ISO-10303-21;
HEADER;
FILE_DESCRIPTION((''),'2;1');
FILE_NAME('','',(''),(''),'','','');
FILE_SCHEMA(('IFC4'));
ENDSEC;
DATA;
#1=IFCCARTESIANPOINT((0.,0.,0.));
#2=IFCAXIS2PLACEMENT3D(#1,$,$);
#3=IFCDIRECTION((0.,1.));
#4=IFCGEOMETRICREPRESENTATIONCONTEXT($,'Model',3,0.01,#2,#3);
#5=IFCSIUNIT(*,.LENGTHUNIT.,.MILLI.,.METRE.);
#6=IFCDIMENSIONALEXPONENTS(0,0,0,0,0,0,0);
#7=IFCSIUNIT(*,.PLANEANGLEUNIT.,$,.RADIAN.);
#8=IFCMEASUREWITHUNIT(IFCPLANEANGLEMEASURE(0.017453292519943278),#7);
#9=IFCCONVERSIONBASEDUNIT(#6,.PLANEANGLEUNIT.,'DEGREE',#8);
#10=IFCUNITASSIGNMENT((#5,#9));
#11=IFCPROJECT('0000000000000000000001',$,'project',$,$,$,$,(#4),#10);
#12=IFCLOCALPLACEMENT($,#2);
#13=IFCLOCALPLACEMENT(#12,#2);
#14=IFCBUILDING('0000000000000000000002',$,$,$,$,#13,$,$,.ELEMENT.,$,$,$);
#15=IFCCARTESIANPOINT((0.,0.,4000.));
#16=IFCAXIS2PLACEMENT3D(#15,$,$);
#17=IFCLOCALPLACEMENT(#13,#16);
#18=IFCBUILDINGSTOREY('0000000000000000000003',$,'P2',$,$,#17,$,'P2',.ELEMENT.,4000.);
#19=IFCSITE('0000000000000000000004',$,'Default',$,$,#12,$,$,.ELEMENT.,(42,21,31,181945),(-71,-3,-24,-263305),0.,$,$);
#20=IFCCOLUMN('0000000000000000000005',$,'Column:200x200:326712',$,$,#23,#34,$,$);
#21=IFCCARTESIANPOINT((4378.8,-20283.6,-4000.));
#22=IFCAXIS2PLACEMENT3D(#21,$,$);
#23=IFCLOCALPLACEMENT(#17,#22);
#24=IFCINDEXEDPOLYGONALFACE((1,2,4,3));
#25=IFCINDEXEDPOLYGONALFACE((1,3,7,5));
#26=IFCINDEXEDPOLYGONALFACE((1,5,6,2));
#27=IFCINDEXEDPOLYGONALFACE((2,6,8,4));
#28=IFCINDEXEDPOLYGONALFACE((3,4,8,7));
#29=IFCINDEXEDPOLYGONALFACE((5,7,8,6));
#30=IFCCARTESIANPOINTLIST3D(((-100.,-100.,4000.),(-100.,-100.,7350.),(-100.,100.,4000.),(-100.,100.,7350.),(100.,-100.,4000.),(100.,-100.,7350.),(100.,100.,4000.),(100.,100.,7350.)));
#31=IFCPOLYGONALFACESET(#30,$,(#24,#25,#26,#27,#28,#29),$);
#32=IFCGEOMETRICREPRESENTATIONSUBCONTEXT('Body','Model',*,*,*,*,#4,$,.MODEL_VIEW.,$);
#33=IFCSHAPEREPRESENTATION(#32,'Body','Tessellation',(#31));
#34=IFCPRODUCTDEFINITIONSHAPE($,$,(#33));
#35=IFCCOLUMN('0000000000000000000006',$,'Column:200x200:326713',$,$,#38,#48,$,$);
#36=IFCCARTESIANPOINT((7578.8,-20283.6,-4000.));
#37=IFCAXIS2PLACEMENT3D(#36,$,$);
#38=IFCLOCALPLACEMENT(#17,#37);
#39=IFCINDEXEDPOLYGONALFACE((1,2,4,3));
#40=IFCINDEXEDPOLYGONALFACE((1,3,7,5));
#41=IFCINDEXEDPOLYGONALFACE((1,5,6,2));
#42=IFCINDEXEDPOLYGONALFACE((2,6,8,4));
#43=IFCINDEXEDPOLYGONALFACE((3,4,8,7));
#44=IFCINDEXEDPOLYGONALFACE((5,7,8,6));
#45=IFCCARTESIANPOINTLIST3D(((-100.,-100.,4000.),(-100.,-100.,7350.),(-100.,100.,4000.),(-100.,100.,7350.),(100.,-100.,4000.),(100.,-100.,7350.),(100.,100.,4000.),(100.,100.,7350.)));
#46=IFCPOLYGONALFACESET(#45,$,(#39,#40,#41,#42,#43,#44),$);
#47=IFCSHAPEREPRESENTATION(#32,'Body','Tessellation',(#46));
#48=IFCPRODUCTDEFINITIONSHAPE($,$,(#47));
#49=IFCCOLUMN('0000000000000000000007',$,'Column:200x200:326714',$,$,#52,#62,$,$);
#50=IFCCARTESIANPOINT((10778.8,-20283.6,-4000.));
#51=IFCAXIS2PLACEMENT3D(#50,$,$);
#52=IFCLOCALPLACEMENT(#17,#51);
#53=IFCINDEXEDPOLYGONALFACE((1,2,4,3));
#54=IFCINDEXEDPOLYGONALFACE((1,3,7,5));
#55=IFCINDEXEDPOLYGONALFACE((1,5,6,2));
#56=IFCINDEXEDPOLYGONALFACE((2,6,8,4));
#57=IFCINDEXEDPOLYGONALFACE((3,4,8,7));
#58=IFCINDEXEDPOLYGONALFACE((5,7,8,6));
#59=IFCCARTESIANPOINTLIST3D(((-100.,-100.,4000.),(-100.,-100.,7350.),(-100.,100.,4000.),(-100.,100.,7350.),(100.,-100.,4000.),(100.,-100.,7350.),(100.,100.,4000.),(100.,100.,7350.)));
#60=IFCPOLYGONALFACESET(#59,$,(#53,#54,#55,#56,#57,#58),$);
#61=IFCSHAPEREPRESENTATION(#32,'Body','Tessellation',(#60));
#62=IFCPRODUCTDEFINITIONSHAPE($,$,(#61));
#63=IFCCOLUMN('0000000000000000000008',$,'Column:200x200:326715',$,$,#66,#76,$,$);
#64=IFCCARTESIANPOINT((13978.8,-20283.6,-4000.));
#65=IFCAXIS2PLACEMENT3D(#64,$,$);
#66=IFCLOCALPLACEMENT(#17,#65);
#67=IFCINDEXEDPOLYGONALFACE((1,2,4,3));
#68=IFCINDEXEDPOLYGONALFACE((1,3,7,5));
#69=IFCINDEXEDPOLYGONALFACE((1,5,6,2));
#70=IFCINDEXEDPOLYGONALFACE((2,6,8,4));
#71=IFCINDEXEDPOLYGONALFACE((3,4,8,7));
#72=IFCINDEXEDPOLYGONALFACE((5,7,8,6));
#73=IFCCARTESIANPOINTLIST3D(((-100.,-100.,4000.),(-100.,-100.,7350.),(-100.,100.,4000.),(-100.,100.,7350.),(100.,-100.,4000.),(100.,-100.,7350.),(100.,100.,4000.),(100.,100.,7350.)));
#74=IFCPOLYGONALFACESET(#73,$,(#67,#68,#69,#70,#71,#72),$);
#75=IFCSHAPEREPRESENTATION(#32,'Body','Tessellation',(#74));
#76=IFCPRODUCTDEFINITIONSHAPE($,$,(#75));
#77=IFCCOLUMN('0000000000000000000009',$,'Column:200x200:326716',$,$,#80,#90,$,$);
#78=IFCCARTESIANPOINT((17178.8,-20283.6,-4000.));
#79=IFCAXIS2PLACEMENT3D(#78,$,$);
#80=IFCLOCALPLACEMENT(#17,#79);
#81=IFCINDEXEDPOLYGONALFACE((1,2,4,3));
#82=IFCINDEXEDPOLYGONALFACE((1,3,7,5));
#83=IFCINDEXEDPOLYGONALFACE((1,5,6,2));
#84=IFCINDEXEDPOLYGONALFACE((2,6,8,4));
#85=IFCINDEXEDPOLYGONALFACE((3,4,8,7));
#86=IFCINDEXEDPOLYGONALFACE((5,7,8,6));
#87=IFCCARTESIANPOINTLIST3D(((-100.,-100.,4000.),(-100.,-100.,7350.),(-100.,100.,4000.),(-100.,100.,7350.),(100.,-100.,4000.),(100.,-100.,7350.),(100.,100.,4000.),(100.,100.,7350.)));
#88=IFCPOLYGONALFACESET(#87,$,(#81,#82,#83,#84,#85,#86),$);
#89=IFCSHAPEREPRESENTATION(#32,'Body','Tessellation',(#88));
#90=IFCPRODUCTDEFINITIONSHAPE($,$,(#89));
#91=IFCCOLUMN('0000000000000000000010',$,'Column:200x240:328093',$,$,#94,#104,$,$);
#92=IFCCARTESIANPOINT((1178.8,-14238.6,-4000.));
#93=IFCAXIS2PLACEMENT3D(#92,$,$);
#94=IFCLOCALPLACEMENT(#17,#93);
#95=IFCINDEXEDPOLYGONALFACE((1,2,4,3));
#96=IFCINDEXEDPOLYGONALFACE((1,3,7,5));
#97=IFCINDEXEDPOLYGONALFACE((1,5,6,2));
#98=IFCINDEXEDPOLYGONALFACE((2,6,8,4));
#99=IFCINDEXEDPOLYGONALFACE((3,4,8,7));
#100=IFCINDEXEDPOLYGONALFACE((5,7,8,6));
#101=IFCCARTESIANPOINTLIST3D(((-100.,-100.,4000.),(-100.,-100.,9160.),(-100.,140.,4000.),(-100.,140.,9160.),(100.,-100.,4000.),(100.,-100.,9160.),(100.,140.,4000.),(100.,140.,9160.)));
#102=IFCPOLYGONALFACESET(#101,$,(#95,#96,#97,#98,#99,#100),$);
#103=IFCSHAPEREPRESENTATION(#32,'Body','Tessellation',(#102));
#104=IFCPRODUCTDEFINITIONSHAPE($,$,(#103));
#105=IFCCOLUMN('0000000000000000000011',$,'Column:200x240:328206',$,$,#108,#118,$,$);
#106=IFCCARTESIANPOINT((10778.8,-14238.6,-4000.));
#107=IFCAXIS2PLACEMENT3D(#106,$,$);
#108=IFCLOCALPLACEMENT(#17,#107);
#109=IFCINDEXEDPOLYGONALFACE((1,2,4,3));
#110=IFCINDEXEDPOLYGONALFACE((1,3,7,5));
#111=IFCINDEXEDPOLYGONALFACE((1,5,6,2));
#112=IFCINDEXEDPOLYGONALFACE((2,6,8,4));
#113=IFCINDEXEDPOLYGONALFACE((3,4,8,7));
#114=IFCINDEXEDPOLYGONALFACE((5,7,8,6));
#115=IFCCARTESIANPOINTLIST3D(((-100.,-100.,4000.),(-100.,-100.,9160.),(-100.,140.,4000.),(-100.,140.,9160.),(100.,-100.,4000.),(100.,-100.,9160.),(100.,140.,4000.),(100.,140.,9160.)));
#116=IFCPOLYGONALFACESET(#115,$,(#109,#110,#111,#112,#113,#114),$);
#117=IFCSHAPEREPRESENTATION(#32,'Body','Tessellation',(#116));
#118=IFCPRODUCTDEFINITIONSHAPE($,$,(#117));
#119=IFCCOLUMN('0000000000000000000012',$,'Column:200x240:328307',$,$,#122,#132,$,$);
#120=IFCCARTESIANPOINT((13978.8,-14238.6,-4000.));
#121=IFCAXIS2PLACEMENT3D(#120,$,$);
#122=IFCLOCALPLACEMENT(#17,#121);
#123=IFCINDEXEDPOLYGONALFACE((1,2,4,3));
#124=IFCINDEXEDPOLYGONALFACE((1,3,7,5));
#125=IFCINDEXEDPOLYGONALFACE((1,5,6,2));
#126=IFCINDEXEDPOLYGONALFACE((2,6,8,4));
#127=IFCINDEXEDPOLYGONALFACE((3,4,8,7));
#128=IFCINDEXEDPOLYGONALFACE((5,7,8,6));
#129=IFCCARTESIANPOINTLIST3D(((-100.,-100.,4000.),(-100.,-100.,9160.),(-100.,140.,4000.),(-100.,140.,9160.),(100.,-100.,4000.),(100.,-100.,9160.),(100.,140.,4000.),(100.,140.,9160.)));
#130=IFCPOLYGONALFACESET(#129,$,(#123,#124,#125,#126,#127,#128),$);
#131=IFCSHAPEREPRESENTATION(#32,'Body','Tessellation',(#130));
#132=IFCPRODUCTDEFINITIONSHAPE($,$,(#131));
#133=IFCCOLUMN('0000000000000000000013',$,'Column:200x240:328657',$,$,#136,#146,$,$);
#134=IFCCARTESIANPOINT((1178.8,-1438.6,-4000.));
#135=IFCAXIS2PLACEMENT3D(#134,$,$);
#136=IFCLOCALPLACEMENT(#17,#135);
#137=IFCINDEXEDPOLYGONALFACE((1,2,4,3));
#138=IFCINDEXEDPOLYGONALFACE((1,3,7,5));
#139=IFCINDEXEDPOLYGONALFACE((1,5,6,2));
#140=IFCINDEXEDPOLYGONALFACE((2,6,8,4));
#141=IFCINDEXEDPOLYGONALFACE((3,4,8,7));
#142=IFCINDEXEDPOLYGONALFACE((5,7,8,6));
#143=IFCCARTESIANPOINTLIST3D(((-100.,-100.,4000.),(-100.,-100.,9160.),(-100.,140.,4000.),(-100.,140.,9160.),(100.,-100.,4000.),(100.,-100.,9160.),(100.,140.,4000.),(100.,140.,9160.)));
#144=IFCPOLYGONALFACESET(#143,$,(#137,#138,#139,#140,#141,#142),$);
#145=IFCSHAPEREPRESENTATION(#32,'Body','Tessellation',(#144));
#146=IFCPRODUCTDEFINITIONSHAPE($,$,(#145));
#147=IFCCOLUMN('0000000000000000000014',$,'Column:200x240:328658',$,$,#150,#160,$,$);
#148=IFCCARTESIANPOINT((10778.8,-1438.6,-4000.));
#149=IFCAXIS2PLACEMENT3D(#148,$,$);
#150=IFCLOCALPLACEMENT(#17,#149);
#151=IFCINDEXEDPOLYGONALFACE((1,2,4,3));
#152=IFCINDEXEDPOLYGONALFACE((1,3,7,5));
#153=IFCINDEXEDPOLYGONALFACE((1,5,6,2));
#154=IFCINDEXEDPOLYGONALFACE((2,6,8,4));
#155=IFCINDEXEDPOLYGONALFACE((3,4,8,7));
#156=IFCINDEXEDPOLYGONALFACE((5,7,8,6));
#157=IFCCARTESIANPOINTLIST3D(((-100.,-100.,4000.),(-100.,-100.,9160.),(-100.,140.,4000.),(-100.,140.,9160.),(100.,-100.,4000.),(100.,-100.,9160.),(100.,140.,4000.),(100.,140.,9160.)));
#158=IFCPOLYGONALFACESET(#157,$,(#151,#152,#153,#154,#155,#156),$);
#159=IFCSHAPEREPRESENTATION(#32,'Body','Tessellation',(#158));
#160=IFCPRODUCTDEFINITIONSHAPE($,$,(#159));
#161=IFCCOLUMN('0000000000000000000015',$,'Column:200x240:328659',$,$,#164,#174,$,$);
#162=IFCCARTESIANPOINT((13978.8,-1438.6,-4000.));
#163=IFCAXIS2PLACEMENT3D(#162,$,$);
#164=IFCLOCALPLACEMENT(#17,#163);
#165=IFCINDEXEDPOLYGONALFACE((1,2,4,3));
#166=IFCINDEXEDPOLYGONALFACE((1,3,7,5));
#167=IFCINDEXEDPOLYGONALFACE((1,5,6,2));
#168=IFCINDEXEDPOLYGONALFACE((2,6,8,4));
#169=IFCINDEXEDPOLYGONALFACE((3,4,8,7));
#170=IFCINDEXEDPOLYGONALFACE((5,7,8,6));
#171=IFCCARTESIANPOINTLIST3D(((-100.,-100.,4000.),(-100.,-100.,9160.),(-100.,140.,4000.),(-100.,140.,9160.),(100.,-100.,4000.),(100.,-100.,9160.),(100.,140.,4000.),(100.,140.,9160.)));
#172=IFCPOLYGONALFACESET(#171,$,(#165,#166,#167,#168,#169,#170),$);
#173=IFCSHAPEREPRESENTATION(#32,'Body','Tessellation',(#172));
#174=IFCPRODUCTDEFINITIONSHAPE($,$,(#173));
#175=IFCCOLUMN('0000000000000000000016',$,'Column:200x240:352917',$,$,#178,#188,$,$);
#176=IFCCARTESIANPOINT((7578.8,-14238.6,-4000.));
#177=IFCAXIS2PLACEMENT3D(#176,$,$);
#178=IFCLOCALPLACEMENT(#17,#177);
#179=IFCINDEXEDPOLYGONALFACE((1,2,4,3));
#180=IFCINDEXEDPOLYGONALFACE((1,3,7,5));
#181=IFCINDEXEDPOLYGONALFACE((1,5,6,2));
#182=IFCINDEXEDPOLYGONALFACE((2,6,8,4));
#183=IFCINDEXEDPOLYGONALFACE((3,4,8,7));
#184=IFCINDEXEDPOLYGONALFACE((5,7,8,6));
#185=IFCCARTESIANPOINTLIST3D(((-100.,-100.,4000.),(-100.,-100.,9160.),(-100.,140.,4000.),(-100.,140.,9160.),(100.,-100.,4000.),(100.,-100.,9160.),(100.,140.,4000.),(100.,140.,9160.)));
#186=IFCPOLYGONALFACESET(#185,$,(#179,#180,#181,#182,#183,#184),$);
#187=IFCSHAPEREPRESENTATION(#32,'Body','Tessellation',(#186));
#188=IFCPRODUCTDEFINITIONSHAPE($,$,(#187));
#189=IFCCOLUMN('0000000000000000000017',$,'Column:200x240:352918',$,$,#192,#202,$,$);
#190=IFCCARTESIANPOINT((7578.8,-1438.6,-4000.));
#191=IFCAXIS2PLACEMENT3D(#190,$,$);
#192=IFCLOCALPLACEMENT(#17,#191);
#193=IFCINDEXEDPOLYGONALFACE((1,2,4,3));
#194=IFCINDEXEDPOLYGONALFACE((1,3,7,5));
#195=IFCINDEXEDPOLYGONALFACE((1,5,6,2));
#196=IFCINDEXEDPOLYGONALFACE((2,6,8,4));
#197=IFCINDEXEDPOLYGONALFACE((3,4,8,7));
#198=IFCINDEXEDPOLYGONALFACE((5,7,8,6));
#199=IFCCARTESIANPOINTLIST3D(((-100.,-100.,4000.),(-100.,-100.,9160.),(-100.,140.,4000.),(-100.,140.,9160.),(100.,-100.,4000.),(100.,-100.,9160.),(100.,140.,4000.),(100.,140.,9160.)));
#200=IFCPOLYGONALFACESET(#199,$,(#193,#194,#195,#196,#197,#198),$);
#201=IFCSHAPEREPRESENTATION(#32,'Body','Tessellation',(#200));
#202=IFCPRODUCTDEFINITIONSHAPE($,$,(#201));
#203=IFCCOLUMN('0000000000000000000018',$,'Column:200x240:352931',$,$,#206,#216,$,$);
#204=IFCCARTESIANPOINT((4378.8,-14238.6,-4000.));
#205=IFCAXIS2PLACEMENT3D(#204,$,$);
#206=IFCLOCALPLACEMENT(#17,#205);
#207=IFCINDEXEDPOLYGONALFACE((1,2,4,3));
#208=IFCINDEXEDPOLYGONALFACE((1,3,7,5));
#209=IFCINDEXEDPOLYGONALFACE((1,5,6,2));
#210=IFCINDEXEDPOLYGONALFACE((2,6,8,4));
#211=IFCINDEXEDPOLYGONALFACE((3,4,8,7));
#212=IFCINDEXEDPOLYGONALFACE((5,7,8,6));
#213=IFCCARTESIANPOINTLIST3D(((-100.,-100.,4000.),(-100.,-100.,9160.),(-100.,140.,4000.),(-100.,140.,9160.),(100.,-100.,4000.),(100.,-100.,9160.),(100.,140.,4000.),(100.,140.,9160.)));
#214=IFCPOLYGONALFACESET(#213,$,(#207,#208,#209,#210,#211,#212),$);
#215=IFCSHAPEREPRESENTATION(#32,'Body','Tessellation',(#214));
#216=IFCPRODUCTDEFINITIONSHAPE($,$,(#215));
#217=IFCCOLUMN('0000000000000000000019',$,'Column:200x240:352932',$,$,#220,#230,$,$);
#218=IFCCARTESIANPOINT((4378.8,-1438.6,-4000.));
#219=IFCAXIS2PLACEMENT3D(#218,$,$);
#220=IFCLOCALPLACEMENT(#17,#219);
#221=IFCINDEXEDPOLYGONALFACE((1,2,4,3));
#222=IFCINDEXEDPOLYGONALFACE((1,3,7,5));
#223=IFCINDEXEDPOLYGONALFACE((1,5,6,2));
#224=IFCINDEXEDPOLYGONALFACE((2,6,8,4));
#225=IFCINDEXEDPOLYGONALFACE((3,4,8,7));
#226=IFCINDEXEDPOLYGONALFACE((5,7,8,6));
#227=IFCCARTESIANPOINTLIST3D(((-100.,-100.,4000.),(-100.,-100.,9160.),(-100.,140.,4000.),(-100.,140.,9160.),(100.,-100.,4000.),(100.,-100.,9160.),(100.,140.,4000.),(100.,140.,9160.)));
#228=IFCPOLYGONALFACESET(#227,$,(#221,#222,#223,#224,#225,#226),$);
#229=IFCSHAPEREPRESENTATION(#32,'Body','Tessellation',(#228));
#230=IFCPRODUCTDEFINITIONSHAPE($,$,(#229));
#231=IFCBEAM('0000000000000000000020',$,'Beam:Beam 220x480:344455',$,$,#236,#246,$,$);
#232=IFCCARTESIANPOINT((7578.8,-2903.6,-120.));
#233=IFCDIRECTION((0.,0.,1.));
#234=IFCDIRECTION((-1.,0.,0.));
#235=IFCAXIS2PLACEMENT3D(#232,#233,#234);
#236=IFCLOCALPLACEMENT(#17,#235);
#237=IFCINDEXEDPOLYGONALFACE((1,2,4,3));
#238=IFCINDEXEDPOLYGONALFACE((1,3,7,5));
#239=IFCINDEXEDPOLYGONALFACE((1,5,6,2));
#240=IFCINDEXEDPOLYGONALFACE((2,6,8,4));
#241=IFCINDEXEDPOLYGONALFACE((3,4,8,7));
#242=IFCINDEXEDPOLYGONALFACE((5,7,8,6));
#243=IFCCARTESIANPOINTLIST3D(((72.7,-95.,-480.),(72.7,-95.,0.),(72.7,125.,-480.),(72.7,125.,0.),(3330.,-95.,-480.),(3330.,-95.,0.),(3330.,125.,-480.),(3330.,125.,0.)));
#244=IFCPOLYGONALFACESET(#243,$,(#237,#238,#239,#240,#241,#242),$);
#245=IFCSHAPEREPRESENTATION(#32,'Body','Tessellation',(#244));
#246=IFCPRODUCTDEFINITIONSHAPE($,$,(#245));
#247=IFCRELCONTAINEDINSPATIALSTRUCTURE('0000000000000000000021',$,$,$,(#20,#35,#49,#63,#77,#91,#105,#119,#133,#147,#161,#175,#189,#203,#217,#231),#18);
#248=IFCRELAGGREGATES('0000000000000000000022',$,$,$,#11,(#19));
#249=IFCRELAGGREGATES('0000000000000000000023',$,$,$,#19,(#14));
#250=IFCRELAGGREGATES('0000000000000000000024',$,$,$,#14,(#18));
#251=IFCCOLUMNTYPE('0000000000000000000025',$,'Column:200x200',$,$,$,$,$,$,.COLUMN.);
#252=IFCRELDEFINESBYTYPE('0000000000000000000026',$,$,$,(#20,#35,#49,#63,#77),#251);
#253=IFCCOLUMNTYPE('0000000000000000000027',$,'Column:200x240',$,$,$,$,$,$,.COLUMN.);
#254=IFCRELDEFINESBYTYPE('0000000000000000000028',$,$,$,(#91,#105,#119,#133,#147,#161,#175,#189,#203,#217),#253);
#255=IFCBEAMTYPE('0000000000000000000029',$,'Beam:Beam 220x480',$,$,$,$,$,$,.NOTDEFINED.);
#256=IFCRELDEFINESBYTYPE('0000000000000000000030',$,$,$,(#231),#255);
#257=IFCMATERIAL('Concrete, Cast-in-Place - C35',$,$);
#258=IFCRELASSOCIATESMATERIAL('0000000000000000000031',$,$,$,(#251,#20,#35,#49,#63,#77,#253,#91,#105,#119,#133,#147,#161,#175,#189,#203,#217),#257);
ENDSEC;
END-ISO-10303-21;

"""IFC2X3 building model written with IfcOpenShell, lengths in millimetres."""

from ifc_helpers import new_model, entity, si_unit, converted_unit, direction, frame, frame_2d, origin, origin_2d_with_axis, place, context, subcontext, project, spatial, rectangle, extrude, source, transform, mapped, material, type_object, type_shapes, element, save


model = new_model("IFC2X3")

# Units and contexts
model_context = context("Model", 3, precision=0.01, world=origin(), true_north=direction((0.0, 1.0)))
body_context = subcontext(model_context, "Body", "Model", "MODEL_VIEW")
ifc_project = project(units=[si_unit("LENGTHUNIT", "METRE", prefix="MILLI"), converted_unit("PLANEANGLEUNIT", "DEGREE", entity("IfcPlaneAngleMeasure", 0.017453292519943278), si_unit("PLANEANGLEUNIT", "RADIAN"), dimensions=[0, 0, 0, 0, 0, 0, 0])], contexts=[model_context])

# Site, building, storey
site_placement = place(None, origin())
site = spatial("IfcSite", under=ifc_project, at=site_placement, Name="Default", CompositionType="ELEMENT", RefLatitude=(42, 21, 31, 181945), RefLongitude=(-71, -3, -24, -263305), RefElevation=0.0)
building_placement = place(site_placement, origin())
building = spatial("IfcBuilding", under=site, at=building_placement, CompositionType="ELEMENT")
storey_placement = place(building_placement, frame((0.0, 0.0, 4000.0)))
storey = spatial("IfcBuildingStorey", under=building, at=storey_placement, Name="P2", LongName="P2", CompositionType="ELEMENT", Elevation=4000.0)

# Columns
ifc_material_1 = material(Name="Concrete, Cast-in-Place - C35")
column_type_1 = type_object("IfcColumnType", Name="Column:200x200", PredefinedType="COLUMN", material=ifc_material_1)
shared_shape_1 = source(origin(), body_context, "Body", "SweptSolid", [
    extrude(rectangle(XDim=200.0, YDim=200.0, at=frame_2d((0.0, 0.0), x_axis=(1.0, 0.0))), frame((0.0, 0.0, 4000.0), z_axis=(0.0, 0.0, 1.0), x_axis=(-1.0, 0.0, 0.0)), (0.0, 0.0, 1.0), 3350.0),
])
type_shapes(column_type_1, [shared_shape_1])
for number, where, name in (
    (1, (4378.8, -20283.6, -4000.0), "Column:200x200:326712"),
    (2, (7578.8, -20283.6, -4000.0), "Column:200x200:326713"),
    (3, (10778.8, -20283.6, -4000.0), "Column:200x200:326714"),
    (4, (13978.8, -20283.6, -4000.0), "Column:200x200:326715"),
    (5, (17178.8, -20283.6, -4000.0), "Column:200x200:326716"),
):
    element("IfcColumn", number, at=place(storey_placement, frame(where)), inside=storey, type_object=column_type_1, material=ifc_material_1, Name=name, context=body_context, shape_type="MappedRepresentation", body=[
        mapped(shared_shape_1, transform((0.0, 0.0, 0.0), scale=1.0)),
    ])
column_type_2 = type_object("IfcColumnType", Name="Column:200x240", PredefinedType="COLUMN", material=ifc_material_1)
shared_shape_2 = source(origin(), body_context, "Body", "SweptSolid", [
    extrude(rectangle(XDim=200.0, YDim=240.0, at=origin_2d_with_axis()), frame((0.0, 20.0, 4000.0), z_axis=(0.0, 0.0, 1.0), x_axis=(-1.0, 0.0, 0.0)), (0.0, 0.0, 1.0), 5160.0),
])
type_shapes(column_type_2, [shared_shape_2])
for number, where, name in (
    (6, (1178.8, -14238.6, -4000.0), "Column:200x240:328093"),
    (7, (10778.8, -14238.6, -4000.0), "Column:200x240:328206"),
    (8, (13978.8, -14238.6, -4000.0), "Column:200x240:328307"),
    (9, (1178.8, -1438.6, -4000.0), "Column:200x240:328657"),
    (10, (10778.8, -1438.6, -4000.0), "Column:200x240:328658"),
    (11, (13978.8, -1438.6, -4000.0), "Column:200x240:328659"),
    (12, (7578.8, -14238.6, -4000.0), "Column:200x240:352917"),
    (13, (7578.8, -1438.6, -4000.0), "Column:200x240:352918"),
    (14, (4378.8, -14238.6, -4000.0), "Column:200x240:352931"),
    (15, (4378.8, -1438.6, -4000.0), "Column:200x240:352932"),
):
    element("IfcColumn", number, at=place(storey_placement, frame(where)), inside=storey, type_object=column_type_2, material=ifc_material_1, Name=name, context=body_context, shape_type="MappedRepresentation", body=[
        mapped(shared_shape_2, transform((0.0, 0.0, 0.0), scale=1.0)),
    ])

# Beam
beam_type_1 = type_object("IfcBeamType", Name="Beam:Beam 220x480", PredefinedType="NOTDEFINED")
beam_1_placement = place(storey_placement, frame((7578.8, -2903.6, -120.0), z_axis=(0.0, 0.0, 1.0), x_axis=(-1.0, 0.0, 0.0)))
element("IfcBeam", 16, at=beam_1_placement, inside=storey, type_object=beam_type_1, Name="Beam:Beam 220x480:344455", context=body_context, shape_type="SweptSolid", body=[
    extrude(rectangle(XDim=480.0, YDim=220.0, at=frame_2d((0.0, 0.0), x_axis=(1.0, 0.0))), frame((72.7, 15.0, -240.0), z_axis=(1.0, 0.0, 0.0), x_axis=(0.0, 0.0, -1.0)), (0.0, 0.0, 1.0), 3257.3),
])

save(model, "model.ifc")
